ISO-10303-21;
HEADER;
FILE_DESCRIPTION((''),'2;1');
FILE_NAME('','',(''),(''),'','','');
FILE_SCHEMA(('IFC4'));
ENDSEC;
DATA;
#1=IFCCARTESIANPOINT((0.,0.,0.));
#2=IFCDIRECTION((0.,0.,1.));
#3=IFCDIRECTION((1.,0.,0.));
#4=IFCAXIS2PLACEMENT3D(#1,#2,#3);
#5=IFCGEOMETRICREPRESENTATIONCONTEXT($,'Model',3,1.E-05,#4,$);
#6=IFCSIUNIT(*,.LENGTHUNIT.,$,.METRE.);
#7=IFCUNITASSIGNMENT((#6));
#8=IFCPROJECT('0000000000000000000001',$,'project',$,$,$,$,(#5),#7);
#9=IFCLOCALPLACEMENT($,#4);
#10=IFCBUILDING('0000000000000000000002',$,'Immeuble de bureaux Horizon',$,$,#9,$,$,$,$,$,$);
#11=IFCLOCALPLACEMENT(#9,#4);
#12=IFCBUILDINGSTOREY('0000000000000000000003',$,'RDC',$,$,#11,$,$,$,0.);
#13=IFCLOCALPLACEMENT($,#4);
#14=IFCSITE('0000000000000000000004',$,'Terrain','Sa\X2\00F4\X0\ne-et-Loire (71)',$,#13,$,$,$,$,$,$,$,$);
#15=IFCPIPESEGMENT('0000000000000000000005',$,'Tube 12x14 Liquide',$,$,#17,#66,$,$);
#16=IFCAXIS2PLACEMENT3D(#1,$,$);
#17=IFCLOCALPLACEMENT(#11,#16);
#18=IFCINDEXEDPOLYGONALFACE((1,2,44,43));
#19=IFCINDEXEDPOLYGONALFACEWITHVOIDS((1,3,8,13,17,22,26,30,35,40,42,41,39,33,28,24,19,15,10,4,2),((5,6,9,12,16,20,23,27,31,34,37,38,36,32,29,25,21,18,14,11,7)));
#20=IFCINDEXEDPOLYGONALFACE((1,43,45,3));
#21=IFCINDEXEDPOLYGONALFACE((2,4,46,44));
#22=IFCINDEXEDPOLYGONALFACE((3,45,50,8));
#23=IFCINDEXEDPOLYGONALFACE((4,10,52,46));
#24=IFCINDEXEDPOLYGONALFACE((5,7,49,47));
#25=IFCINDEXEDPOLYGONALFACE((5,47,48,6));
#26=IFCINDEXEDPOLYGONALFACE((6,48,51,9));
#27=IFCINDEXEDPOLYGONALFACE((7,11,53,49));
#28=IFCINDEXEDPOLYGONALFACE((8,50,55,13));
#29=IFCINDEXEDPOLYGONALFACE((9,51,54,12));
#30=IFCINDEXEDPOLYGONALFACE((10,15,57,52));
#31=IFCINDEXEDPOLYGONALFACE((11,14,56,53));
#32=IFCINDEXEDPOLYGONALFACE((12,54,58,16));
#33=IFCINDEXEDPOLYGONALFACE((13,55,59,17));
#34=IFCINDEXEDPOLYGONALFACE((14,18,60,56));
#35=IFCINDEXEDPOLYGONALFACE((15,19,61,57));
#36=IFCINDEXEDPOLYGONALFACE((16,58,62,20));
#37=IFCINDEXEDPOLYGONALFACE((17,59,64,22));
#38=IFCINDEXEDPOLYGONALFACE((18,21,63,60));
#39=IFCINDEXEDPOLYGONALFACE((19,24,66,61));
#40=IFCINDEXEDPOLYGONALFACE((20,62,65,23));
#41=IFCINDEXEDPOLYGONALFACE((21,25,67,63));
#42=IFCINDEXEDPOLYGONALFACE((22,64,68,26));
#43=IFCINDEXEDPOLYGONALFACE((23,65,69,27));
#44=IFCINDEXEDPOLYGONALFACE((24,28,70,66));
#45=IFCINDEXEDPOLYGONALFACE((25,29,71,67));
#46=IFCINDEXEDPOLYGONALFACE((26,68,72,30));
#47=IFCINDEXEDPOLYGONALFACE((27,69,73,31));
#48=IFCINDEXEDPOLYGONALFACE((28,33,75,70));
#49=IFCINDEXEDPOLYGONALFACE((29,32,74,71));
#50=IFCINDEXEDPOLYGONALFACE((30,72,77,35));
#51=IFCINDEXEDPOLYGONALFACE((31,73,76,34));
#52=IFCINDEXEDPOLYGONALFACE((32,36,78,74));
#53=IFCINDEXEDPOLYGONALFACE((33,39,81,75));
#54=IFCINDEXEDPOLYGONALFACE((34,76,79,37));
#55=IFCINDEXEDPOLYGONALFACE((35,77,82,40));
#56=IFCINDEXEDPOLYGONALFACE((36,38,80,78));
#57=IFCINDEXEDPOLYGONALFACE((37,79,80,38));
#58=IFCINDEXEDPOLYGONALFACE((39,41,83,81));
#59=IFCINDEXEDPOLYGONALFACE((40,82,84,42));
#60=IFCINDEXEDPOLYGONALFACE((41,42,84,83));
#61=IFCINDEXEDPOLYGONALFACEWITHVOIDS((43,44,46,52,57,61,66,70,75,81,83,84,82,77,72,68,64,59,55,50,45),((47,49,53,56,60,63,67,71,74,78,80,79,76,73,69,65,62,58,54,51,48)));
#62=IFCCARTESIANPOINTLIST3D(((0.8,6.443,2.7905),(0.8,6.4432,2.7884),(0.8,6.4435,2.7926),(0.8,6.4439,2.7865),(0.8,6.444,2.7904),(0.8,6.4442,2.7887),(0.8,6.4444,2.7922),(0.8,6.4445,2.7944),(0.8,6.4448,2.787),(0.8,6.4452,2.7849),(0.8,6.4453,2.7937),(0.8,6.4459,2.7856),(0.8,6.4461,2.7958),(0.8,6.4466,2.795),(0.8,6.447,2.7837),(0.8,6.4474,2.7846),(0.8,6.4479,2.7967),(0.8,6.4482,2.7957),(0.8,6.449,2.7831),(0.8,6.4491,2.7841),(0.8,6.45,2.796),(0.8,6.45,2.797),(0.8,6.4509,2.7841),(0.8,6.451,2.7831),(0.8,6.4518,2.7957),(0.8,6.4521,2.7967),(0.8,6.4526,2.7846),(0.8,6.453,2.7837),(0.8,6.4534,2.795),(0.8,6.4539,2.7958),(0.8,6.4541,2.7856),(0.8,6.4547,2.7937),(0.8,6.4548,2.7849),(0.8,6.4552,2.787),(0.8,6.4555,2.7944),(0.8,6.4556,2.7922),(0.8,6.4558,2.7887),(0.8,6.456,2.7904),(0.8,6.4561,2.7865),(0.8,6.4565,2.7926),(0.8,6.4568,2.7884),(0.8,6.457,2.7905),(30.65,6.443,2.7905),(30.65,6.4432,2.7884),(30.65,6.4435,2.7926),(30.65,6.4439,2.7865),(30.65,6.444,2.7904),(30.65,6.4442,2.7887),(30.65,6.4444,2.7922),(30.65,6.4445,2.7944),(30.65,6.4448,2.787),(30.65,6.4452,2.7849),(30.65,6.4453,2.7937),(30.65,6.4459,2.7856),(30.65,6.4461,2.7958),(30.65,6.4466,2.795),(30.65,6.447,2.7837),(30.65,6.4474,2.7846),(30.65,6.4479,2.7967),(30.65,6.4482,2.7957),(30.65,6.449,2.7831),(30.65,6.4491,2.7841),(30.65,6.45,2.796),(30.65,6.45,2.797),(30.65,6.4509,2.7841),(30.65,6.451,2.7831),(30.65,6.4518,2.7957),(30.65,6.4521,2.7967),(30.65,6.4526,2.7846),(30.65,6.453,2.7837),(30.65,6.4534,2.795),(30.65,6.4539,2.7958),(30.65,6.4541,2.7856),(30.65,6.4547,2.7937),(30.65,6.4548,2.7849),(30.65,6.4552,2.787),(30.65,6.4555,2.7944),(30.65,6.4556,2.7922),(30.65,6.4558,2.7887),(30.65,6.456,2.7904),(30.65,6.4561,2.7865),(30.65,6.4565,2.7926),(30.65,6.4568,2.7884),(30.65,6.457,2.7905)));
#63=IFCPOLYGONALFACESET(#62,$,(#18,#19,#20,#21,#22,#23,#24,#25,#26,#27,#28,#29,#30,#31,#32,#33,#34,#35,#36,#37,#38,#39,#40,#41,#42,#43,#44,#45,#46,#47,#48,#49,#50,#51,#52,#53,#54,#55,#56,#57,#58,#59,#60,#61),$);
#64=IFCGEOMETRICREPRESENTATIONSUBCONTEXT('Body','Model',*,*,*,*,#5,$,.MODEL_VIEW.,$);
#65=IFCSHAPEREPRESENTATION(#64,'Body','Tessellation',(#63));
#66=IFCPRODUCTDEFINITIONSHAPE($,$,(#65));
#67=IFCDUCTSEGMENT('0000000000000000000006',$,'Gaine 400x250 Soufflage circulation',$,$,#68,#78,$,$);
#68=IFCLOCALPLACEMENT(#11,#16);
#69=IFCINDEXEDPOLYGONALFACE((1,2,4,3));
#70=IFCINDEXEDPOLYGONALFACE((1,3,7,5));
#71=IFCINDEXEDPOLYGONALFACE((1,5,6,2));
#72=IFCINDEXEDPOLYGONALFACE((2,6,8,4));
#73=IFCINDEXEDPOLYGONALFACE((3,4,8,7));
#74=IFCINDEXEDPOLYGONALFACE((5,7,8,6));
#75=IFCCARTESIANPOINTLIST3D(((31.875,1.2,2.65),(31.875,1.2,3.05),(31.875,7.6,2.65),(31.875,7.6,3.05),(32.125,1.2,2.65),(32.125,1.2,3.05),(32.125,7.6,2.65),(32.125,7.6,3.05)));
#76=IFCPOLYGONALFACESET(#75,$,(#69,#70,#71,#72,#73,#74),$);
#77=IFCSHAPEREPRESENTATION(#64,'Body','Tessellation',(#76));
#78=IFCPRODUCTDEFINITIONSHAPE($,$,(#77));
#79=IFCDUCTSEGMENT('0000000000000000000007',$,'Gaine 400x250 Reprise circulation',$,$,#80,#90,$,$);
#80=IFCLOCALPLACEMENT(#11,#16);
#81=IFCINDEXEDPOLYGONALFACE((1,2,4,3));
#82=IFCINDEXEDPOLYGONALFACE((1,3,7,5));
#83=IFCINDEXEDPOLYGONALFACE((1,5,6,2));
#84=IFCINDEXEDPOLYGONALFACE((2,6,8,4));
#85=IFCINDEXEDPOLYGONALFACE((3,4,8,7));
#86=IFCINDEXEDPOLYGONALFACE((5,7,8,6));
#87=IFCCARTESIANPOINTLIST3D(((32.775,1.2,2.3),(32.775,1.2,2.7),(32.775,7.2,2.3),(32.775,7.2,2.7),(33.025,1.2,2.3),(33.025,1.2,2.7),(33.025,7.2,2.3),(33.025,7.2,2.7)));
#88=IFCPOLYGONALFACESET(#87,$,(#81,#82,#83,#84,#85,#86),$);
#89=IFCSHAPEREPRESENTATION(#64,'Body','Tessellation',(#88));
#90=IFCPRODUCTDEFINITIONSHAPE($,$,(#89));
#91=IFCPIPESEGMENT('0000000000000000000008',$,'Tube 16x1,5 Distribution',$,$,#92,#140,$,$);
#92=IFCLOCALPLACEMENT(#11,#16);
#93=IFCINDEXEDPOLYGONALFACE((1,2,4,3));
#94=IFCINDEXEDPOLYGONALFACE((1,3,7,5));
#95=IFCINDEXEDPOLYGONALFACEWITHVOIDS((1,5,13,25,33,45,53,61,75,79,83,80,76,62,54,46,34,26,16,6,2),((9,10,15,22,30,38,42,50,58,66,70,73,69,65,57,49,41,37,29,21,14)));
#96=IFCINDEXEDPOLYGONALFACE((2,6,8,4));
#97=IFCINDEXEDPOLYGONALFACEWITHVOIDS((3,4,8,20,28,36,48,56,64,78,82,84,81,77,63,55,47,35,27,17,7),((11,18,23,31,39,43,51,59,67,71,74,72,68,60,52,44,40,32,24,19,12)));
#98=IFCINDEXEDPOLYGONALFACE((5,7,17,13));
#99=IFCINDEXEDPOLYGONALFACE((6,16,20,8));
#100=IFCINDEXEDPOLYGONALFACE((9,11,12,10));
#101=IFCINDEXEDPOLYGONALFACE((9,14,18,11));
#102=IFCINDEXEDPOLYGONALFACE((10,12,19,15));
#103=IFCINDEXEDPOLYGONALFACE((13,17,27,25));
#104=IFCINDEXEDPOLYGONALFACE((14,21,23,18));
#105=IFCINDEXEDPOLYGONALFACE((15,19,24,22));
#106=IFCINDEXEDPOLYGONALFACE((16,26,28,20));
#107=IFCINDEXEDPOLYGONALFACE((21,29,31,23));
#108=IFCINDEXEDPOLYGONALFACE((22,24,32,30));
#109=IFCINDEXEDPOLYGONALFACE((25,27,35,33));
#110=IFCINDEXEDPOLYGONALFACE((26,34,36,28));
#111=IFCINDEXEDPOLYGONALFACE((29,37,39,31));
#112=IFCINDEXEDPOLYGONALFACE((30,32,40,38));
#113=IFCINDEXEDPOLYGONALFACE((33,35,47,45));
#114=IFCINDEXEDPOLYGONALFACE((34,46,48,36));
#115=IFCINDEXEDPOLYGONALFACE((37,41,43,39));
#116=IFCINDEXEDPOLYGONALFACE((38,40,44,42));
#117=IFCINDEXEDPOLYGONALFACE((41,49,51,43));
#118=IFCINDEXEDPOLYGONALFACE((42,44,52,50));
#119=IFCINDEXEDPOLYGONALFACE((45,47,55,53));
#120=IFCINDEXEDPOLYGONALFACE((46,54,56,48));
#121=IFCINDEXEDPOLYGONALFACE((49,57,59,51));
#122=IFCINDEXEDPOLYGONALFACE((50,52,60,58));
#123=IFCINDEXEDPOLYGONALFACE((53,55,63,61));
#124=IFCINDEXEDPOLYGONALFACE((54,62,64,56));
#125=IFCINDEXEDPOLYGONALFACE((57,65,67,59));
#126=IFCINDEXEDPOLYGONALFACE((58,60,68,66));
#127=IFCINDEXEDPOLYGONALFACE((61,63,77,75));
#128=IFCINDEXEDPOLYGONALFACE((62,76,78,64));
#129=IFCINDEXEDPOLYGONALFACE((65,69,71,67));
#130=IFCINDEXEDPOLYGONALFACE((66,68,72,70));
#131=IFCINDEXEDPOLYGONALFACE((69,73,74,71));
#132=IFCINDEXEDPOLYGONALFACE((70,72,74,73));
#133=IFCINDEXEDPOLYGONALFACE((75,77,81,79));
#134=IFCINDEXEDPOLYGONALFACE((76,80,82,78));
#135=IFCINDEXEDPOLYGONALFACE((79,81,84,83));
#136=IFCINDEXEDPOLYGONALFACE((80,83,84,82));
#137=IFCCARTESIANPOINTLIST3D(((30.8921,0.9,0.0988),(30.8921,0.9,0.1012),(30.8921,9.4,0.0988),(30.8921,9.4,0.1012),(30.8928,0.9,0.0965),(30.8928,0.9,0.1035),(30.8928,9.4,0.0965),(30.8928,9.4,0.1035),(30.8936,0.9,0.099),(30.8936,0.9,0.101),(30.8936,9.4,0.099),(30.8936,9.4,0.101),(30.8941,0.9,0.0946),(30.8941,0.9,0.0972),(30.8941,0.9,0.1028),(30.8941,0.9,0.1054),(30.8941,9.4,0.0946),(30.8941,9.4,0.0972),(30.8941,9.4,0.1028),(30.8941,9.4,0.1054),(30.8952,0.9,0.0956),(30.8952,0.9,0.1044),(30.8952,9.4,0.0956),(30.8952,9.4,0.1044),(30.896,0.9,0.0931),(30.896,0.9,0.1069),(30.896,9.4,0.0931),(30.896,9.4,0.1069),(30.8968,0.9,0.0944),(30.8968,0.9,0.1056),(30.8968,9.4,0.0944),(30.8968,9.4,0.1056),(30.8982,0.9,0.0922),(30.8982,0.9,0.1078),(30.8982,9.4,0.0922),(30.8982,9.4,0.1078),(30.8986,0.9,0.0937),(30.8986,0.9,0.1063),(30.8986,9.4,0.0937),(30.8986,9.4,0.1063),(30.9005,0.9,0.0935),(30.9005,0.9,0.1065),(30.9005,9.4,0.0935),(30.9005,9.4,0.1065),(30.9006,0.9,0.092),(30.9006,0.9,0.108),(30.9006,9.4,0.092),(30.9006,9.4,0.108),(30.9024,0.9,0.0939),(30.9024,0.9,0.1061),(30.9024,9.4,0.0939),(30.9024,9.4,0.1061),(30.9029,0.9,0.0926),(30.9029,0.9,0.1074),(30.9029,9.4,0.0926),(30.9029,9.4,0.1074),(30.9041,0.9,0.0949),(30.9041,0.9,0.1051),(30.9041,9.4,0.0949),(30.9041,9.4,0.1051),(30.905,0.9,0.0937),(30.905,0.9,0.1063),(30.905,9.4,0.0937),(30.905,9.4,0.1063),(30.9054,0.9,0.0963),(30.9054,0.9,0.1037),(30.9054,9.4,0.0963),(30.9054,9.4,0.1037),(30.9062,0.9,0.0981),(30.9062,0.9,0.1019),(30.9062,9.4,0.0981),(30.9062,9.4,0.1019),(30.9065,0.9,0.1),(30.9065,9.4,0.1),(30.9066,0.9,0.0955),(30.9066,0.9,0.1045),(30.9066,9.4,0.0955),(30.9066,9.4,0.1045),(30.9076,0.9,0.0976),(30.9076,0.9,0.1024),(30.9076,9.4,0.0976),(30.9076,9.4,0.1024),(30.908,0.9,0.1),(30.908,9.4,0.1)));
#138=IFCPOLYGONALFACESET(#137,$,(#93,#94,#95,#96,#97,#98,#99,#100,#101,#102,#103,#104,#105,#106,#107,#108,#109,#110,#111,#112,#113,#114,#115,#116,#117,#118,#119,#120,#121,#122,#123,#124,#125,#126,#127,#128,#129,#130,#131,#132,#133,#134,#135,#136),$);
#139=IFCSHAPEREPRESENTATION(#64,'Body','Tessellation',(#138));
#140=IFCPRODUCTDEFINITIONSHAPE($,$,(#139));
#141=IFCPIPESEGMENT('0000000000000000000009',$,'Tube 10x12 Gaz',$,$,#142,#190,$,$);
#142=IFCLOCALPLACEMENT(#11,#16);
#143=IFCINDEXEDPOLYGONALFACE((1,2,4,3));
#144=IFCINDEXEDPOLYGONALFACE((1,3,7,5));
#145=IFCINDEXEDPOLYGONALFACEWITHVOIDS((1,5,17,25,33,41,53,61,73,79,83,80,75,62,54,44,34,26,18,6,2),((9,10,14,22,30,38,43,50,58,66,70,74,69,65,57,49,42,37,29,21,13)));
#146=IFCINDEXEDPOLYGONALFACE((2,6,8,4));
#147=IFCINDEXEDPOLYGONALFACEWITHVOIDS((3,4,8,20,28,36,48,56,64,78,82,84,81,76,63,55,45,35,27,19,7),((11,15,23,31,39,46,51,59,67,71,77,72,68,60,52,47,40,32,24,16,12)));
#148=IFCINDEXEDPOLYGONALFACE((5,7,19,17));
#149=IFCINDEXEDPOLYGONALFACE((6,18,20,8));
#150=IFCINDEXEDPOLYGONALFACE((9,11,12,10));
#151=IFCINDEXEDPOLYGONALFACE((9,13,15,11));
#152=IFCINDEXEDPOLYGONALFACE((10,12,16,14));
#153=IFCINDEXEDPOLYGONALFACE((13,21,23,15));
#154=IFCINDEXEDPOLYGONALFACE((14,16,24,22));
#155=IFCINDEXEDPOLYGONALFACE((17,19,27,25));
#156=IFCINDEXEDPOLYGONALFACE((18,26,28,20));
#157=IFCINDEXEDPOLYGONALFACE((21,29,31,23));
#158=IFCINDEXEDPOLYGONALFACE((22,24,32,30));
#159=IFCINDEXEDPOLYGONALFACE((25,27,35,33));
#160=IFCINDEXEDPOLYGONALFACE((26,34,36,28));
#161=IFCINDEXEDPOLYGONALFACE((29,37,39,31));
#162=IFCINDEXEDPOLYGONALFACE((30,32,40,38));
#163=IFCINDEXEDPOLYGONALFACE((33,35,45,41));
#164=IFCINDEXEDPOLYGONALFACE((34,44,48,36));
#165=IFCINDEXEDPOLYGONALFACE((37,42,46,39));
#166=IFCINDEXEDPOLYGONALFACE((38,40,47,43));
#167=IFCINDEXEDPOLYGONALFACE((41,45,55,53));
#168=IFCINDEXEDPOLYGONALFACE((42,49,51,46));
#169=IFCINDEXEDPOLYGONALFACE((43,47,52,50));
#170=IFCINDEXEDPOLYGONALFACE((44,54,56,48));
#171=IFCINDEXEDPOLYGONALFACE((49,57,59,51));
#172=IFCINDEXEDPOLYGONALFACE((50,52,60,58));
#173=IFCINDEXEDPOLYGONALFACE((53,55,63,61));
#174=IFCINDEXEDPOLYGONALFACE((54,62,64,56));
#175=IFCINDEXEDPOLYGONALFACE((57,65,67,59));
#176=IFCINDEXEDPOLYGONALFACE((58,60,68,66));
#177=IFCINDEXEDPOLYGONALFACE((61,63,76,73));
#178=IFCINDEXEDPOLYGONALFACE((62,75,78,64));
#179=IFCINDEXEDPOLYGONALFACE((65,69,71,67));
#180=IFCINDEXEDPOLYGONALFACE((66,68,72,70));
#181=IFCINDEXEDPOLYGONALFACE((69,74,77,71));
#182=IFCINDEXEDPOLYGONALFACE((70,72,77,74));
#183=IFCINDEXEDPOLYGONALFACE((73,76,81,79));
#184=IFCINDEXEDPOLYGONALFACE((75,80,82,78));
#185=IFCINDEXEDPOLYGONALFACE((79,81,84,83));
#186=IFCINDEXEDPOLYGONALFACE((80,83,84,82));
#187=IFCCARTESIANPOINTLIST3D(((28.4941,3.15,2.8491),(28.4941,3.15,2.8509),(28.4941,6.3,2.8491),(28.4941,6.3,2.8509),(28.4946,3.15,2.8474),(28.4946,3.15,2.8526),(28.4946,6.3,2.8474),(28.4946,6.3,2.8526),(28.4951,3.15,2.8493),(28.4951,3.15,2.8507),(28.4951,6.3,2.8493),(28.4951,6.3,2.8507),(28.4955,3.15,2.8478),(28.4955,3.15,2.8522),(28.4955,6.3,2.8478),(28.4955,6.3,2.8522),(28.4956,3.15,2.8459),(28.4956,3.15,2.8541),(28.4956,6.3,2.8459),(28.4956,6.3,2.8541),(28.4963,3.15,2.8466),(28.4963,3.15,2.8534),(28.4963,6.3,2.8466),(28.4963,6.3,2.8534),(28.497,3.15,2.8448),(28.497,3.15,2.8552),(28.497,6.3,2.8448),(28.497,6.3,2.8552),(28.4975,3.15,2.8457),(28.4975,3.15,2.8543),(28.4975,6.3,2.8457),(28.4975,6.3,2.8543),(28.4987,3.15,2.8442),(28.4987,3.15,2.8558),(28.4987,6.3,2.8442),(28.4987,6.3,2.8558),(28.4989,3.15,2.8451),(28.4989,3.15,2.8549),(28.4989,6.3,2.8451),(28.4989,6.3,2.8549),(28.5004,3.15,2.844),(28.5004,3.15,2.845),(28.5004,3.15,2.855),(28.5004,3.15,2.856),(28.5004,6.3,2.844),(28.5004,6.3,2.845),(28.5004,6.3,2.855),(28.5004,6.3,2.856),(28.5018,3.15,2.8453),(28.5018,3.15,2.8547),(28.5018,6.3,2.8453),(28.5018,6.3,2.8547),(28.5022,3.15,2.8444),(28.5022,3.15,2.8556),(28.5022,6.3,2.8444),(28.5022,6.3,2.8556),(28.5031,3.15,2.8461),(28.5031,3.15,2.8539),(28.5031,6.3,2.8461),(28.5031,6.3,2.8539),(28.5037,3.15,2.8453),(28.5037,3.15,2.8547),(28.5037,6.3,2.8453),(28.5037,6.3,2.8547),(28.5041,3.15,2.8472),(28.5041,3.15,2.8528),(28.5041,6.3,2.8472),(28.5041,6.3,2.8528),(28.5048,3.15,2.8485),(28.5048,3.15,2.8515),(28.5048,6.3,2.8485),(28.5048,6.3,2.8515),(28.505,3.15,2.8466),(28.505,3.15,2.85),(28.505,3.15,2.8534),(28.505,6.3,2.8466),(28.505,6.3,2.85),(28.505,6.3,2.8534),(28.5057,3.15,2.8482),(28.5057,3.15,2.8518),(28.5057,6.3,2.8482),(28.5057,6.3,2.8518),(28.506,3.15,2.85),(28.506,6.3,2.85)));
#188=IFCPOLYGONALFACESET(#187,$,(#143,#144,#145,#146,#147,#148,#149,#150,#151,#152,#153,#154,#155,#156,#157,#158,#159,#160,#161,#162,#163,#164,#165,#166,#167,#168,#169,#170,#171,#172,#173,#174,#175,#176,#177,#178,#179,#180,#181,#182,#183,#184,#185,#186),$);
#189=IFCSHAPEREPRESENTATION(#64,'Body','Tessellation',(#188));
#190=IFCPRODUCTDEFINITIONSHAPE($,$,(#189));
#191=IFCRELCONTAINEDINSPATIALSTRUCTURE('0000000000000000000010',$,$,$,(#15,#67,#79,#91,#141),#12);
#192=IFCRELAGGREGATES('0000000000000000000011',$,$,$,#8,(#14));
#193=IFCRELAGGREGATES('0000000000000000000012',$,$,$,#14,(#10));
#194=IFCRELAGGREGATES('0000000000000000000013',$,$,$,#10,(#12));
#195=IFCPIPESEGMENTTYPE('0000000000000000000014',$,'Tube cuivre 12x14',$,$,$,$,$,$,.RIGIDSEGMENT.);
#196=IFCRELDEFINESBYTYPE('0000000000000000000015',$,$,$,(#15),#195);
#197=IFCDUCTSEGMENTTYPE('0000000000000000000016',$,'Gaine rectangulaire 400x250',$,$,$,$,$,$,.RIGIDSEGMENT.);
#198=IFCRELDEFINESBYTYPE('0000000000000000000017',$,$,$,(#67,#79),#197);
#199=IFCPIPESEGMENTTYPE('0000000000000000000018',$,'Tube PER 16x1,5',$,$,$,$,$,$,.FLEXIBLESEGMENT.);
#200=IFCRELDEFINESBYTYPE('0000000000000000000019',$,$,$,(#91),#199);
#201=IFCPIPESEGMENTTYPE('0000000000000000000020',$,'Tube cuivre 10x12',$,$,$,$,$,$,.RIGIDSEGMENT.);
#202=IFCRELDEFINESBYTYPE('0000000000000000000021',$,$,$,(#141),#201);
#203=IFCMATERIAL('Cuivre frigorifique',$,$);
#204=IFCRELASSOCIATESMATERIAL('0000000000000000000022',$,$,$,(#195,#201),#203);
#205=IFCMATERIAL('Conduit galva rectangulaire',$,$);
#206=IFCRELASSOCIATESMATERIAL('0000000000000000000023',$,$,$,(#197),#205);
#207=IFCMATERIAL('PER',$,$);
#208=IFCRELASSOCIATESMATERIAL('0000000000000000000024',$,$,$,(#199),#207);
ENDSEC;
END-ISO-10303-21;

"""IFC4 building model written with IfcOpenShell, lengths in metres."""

from ifc_helpers import new_model, si_unit, frame, origin_with_axes, origin_2d, place, context, subcontext, project, spatial, rectangle, hollow_circle, extrude, material, type_object, element, save


model = new_model("IFC4")

# Units and contexts
model_context = context("Model", 3, precision=1e-05, world=origin_with_axes())
body_context = subcontext(model_context, "Body", "Model", "MODEL_VIEW")
ifc_project = project(units=[si_unit("LENGTHUNIT", "METRE")], contexts=[model_context])

# Site, building, storey
site_placement = place(None, origin_with_axes())
site = spatial("IfcSite", under=ifc_project, at=site_placement, Name="Terrain", Description="Saône-et-Loire (71)")
building_placement = place(None, origin_with_axes())
building = spatial("IfcBuilding", under=site, at=building_placement, Name="Immeuble de bureaux Horizon")
storey_placement = place(building_placement, origin_with_axes())
storey = spatial("IfcBuildingStorey", under=building, at=storey_placement, Name="RDC", Elevation=0.0)

# Shared definitions
ifc_material_1 = material(Name="Cuivre frigorifique")

# Shared definitions
ifc_material_2 = material(Name="Conduit galva rectangulaire")

# Pipe segment
pipe_segment_type_1 = type_object("IfcPipeSegmentType", Name="Tube cuivre 12x14", PredefinedType="RIGIDSEGMENT", material=ifc_material_1)
pipe_segment_1_placement = place(storey_placement, frame((30.65, 6.45, 2.79), z_axis=(-1.0, 0.0, 0.0), x_axis=(0.0, 0.0, 1.0)))
element("IfcPipeSegment", 1, at=pipe_segment_1_placement, inside=storey, type_object=pipe_segment_type_1, Name="Tube 12x14 Liquide", context=body_context, shape_type="SweptSolid", body=[
    extrude(hollow_circle(Radius=0.007, WallThickness=0.001), origin_with_axes(), (0.0, 0.0, 1.0), 29.85),
])

# Duct segments
duct_segment_type_1 = type_object("IfcDuctSegmentType", Name="Gaine rectangulaire 400x250", PredefinedType="RIGIDSEGMENT", material=ifc_material_2)
duct_segment_1_placement = place(storey_placement, frame((32.0, 1.2, 2.85), z_axis=(0.0, 1.0, 0.0), x_axis=(0.0, 0.0, 1.0)))
element("IfcDuctSegment", 2, at=duct_segment_1_placement, inside=storey, type_object=duct_segment_type_1, Name="Gaine 400x250 Soufflage circulation", context=body_context, shape_type="SweptSolid", body=[
    extrude(rectangle(XDim=0.4, YDim=0.25, at=origin_2d()), origin_with_axes(), (0.0, 0.0, 1.0), 6.4),
])
duct_segment_2_placement = place(storey_placement, frame((32.9, 1.2, 2.5), z_axis=(0.0, 1.0, 0.0), x_axis=(0.0, 0.0, 1.0)))
element("IfcDuctSegment", 3, at=duct_segment_2_placement, inside=storey, type_object=duct_segment_type_1, Name="Gaine 400x250 Reprise circulation", context=body_context, shape_type="SweptSolid", body=[
    extrude(rectangle(XDim=0.4, YDim=0.25, at=origin_2d()), origin_with_axes(), (0.0, 0.0, 1.0), 6.0),
])

# Pipe segments
ifc_material_3 = material(Name="PER")
pipe_segment_type_2 = type_object("IfcPipeSegmentType", Name="Tube PER 16x1,5", PredefinedType="FLEXIBLESEGMENT", material=ifc_material_3)
pipe_segment_2_placement = place(storey_placement, frame((30.9, 0.9, 0.1), z_axis=(0.0, 1.0, 0.0), x_axis=(1.0, 0.0, 0.0)))
element("IfcPipeSegment", 4, at=pipe_segment_2_placement, inside=storey, type_object=pipe_segment_type_2, Name="Tube 16x1,5 Distribution", context=body_context, shape_type="SweptSolid", body=[
    extrude(hollow_circle(Radius=0.008, WallThickness=0.0015), origin_with_axes(), (0.0, 0.0, 1.0), 8.5),
])
pipe_segment_type_3 = type_object("IfcPipeSegmentType", Name="Tube cuivre 10x12", PredefinedType="RIGIDSEGMENT", material=ifc_material_1)
pipe_segment_3_placement = place(storey_placement, frame((28.5, 6.3, 2.85), z_axis=(0.0, -1.0, 0.0), x_axis=(1.0, 0.0, 0.0)))
element("IfcPipeSegment", 5, at=pipe_segment_3_placement, inside=storey, type_object=pipe_segment_type_3, Name="Tube 10x12 Gaz", context=body_context, shape_type="SweptSolid", body=[
    extrude(hollow_circle(Radius=0.006, WallThickness=0.001), origin_with_axes(), (0.0, 0.0, 1.0), 3.15),
])

save(model, "model.ifc")
